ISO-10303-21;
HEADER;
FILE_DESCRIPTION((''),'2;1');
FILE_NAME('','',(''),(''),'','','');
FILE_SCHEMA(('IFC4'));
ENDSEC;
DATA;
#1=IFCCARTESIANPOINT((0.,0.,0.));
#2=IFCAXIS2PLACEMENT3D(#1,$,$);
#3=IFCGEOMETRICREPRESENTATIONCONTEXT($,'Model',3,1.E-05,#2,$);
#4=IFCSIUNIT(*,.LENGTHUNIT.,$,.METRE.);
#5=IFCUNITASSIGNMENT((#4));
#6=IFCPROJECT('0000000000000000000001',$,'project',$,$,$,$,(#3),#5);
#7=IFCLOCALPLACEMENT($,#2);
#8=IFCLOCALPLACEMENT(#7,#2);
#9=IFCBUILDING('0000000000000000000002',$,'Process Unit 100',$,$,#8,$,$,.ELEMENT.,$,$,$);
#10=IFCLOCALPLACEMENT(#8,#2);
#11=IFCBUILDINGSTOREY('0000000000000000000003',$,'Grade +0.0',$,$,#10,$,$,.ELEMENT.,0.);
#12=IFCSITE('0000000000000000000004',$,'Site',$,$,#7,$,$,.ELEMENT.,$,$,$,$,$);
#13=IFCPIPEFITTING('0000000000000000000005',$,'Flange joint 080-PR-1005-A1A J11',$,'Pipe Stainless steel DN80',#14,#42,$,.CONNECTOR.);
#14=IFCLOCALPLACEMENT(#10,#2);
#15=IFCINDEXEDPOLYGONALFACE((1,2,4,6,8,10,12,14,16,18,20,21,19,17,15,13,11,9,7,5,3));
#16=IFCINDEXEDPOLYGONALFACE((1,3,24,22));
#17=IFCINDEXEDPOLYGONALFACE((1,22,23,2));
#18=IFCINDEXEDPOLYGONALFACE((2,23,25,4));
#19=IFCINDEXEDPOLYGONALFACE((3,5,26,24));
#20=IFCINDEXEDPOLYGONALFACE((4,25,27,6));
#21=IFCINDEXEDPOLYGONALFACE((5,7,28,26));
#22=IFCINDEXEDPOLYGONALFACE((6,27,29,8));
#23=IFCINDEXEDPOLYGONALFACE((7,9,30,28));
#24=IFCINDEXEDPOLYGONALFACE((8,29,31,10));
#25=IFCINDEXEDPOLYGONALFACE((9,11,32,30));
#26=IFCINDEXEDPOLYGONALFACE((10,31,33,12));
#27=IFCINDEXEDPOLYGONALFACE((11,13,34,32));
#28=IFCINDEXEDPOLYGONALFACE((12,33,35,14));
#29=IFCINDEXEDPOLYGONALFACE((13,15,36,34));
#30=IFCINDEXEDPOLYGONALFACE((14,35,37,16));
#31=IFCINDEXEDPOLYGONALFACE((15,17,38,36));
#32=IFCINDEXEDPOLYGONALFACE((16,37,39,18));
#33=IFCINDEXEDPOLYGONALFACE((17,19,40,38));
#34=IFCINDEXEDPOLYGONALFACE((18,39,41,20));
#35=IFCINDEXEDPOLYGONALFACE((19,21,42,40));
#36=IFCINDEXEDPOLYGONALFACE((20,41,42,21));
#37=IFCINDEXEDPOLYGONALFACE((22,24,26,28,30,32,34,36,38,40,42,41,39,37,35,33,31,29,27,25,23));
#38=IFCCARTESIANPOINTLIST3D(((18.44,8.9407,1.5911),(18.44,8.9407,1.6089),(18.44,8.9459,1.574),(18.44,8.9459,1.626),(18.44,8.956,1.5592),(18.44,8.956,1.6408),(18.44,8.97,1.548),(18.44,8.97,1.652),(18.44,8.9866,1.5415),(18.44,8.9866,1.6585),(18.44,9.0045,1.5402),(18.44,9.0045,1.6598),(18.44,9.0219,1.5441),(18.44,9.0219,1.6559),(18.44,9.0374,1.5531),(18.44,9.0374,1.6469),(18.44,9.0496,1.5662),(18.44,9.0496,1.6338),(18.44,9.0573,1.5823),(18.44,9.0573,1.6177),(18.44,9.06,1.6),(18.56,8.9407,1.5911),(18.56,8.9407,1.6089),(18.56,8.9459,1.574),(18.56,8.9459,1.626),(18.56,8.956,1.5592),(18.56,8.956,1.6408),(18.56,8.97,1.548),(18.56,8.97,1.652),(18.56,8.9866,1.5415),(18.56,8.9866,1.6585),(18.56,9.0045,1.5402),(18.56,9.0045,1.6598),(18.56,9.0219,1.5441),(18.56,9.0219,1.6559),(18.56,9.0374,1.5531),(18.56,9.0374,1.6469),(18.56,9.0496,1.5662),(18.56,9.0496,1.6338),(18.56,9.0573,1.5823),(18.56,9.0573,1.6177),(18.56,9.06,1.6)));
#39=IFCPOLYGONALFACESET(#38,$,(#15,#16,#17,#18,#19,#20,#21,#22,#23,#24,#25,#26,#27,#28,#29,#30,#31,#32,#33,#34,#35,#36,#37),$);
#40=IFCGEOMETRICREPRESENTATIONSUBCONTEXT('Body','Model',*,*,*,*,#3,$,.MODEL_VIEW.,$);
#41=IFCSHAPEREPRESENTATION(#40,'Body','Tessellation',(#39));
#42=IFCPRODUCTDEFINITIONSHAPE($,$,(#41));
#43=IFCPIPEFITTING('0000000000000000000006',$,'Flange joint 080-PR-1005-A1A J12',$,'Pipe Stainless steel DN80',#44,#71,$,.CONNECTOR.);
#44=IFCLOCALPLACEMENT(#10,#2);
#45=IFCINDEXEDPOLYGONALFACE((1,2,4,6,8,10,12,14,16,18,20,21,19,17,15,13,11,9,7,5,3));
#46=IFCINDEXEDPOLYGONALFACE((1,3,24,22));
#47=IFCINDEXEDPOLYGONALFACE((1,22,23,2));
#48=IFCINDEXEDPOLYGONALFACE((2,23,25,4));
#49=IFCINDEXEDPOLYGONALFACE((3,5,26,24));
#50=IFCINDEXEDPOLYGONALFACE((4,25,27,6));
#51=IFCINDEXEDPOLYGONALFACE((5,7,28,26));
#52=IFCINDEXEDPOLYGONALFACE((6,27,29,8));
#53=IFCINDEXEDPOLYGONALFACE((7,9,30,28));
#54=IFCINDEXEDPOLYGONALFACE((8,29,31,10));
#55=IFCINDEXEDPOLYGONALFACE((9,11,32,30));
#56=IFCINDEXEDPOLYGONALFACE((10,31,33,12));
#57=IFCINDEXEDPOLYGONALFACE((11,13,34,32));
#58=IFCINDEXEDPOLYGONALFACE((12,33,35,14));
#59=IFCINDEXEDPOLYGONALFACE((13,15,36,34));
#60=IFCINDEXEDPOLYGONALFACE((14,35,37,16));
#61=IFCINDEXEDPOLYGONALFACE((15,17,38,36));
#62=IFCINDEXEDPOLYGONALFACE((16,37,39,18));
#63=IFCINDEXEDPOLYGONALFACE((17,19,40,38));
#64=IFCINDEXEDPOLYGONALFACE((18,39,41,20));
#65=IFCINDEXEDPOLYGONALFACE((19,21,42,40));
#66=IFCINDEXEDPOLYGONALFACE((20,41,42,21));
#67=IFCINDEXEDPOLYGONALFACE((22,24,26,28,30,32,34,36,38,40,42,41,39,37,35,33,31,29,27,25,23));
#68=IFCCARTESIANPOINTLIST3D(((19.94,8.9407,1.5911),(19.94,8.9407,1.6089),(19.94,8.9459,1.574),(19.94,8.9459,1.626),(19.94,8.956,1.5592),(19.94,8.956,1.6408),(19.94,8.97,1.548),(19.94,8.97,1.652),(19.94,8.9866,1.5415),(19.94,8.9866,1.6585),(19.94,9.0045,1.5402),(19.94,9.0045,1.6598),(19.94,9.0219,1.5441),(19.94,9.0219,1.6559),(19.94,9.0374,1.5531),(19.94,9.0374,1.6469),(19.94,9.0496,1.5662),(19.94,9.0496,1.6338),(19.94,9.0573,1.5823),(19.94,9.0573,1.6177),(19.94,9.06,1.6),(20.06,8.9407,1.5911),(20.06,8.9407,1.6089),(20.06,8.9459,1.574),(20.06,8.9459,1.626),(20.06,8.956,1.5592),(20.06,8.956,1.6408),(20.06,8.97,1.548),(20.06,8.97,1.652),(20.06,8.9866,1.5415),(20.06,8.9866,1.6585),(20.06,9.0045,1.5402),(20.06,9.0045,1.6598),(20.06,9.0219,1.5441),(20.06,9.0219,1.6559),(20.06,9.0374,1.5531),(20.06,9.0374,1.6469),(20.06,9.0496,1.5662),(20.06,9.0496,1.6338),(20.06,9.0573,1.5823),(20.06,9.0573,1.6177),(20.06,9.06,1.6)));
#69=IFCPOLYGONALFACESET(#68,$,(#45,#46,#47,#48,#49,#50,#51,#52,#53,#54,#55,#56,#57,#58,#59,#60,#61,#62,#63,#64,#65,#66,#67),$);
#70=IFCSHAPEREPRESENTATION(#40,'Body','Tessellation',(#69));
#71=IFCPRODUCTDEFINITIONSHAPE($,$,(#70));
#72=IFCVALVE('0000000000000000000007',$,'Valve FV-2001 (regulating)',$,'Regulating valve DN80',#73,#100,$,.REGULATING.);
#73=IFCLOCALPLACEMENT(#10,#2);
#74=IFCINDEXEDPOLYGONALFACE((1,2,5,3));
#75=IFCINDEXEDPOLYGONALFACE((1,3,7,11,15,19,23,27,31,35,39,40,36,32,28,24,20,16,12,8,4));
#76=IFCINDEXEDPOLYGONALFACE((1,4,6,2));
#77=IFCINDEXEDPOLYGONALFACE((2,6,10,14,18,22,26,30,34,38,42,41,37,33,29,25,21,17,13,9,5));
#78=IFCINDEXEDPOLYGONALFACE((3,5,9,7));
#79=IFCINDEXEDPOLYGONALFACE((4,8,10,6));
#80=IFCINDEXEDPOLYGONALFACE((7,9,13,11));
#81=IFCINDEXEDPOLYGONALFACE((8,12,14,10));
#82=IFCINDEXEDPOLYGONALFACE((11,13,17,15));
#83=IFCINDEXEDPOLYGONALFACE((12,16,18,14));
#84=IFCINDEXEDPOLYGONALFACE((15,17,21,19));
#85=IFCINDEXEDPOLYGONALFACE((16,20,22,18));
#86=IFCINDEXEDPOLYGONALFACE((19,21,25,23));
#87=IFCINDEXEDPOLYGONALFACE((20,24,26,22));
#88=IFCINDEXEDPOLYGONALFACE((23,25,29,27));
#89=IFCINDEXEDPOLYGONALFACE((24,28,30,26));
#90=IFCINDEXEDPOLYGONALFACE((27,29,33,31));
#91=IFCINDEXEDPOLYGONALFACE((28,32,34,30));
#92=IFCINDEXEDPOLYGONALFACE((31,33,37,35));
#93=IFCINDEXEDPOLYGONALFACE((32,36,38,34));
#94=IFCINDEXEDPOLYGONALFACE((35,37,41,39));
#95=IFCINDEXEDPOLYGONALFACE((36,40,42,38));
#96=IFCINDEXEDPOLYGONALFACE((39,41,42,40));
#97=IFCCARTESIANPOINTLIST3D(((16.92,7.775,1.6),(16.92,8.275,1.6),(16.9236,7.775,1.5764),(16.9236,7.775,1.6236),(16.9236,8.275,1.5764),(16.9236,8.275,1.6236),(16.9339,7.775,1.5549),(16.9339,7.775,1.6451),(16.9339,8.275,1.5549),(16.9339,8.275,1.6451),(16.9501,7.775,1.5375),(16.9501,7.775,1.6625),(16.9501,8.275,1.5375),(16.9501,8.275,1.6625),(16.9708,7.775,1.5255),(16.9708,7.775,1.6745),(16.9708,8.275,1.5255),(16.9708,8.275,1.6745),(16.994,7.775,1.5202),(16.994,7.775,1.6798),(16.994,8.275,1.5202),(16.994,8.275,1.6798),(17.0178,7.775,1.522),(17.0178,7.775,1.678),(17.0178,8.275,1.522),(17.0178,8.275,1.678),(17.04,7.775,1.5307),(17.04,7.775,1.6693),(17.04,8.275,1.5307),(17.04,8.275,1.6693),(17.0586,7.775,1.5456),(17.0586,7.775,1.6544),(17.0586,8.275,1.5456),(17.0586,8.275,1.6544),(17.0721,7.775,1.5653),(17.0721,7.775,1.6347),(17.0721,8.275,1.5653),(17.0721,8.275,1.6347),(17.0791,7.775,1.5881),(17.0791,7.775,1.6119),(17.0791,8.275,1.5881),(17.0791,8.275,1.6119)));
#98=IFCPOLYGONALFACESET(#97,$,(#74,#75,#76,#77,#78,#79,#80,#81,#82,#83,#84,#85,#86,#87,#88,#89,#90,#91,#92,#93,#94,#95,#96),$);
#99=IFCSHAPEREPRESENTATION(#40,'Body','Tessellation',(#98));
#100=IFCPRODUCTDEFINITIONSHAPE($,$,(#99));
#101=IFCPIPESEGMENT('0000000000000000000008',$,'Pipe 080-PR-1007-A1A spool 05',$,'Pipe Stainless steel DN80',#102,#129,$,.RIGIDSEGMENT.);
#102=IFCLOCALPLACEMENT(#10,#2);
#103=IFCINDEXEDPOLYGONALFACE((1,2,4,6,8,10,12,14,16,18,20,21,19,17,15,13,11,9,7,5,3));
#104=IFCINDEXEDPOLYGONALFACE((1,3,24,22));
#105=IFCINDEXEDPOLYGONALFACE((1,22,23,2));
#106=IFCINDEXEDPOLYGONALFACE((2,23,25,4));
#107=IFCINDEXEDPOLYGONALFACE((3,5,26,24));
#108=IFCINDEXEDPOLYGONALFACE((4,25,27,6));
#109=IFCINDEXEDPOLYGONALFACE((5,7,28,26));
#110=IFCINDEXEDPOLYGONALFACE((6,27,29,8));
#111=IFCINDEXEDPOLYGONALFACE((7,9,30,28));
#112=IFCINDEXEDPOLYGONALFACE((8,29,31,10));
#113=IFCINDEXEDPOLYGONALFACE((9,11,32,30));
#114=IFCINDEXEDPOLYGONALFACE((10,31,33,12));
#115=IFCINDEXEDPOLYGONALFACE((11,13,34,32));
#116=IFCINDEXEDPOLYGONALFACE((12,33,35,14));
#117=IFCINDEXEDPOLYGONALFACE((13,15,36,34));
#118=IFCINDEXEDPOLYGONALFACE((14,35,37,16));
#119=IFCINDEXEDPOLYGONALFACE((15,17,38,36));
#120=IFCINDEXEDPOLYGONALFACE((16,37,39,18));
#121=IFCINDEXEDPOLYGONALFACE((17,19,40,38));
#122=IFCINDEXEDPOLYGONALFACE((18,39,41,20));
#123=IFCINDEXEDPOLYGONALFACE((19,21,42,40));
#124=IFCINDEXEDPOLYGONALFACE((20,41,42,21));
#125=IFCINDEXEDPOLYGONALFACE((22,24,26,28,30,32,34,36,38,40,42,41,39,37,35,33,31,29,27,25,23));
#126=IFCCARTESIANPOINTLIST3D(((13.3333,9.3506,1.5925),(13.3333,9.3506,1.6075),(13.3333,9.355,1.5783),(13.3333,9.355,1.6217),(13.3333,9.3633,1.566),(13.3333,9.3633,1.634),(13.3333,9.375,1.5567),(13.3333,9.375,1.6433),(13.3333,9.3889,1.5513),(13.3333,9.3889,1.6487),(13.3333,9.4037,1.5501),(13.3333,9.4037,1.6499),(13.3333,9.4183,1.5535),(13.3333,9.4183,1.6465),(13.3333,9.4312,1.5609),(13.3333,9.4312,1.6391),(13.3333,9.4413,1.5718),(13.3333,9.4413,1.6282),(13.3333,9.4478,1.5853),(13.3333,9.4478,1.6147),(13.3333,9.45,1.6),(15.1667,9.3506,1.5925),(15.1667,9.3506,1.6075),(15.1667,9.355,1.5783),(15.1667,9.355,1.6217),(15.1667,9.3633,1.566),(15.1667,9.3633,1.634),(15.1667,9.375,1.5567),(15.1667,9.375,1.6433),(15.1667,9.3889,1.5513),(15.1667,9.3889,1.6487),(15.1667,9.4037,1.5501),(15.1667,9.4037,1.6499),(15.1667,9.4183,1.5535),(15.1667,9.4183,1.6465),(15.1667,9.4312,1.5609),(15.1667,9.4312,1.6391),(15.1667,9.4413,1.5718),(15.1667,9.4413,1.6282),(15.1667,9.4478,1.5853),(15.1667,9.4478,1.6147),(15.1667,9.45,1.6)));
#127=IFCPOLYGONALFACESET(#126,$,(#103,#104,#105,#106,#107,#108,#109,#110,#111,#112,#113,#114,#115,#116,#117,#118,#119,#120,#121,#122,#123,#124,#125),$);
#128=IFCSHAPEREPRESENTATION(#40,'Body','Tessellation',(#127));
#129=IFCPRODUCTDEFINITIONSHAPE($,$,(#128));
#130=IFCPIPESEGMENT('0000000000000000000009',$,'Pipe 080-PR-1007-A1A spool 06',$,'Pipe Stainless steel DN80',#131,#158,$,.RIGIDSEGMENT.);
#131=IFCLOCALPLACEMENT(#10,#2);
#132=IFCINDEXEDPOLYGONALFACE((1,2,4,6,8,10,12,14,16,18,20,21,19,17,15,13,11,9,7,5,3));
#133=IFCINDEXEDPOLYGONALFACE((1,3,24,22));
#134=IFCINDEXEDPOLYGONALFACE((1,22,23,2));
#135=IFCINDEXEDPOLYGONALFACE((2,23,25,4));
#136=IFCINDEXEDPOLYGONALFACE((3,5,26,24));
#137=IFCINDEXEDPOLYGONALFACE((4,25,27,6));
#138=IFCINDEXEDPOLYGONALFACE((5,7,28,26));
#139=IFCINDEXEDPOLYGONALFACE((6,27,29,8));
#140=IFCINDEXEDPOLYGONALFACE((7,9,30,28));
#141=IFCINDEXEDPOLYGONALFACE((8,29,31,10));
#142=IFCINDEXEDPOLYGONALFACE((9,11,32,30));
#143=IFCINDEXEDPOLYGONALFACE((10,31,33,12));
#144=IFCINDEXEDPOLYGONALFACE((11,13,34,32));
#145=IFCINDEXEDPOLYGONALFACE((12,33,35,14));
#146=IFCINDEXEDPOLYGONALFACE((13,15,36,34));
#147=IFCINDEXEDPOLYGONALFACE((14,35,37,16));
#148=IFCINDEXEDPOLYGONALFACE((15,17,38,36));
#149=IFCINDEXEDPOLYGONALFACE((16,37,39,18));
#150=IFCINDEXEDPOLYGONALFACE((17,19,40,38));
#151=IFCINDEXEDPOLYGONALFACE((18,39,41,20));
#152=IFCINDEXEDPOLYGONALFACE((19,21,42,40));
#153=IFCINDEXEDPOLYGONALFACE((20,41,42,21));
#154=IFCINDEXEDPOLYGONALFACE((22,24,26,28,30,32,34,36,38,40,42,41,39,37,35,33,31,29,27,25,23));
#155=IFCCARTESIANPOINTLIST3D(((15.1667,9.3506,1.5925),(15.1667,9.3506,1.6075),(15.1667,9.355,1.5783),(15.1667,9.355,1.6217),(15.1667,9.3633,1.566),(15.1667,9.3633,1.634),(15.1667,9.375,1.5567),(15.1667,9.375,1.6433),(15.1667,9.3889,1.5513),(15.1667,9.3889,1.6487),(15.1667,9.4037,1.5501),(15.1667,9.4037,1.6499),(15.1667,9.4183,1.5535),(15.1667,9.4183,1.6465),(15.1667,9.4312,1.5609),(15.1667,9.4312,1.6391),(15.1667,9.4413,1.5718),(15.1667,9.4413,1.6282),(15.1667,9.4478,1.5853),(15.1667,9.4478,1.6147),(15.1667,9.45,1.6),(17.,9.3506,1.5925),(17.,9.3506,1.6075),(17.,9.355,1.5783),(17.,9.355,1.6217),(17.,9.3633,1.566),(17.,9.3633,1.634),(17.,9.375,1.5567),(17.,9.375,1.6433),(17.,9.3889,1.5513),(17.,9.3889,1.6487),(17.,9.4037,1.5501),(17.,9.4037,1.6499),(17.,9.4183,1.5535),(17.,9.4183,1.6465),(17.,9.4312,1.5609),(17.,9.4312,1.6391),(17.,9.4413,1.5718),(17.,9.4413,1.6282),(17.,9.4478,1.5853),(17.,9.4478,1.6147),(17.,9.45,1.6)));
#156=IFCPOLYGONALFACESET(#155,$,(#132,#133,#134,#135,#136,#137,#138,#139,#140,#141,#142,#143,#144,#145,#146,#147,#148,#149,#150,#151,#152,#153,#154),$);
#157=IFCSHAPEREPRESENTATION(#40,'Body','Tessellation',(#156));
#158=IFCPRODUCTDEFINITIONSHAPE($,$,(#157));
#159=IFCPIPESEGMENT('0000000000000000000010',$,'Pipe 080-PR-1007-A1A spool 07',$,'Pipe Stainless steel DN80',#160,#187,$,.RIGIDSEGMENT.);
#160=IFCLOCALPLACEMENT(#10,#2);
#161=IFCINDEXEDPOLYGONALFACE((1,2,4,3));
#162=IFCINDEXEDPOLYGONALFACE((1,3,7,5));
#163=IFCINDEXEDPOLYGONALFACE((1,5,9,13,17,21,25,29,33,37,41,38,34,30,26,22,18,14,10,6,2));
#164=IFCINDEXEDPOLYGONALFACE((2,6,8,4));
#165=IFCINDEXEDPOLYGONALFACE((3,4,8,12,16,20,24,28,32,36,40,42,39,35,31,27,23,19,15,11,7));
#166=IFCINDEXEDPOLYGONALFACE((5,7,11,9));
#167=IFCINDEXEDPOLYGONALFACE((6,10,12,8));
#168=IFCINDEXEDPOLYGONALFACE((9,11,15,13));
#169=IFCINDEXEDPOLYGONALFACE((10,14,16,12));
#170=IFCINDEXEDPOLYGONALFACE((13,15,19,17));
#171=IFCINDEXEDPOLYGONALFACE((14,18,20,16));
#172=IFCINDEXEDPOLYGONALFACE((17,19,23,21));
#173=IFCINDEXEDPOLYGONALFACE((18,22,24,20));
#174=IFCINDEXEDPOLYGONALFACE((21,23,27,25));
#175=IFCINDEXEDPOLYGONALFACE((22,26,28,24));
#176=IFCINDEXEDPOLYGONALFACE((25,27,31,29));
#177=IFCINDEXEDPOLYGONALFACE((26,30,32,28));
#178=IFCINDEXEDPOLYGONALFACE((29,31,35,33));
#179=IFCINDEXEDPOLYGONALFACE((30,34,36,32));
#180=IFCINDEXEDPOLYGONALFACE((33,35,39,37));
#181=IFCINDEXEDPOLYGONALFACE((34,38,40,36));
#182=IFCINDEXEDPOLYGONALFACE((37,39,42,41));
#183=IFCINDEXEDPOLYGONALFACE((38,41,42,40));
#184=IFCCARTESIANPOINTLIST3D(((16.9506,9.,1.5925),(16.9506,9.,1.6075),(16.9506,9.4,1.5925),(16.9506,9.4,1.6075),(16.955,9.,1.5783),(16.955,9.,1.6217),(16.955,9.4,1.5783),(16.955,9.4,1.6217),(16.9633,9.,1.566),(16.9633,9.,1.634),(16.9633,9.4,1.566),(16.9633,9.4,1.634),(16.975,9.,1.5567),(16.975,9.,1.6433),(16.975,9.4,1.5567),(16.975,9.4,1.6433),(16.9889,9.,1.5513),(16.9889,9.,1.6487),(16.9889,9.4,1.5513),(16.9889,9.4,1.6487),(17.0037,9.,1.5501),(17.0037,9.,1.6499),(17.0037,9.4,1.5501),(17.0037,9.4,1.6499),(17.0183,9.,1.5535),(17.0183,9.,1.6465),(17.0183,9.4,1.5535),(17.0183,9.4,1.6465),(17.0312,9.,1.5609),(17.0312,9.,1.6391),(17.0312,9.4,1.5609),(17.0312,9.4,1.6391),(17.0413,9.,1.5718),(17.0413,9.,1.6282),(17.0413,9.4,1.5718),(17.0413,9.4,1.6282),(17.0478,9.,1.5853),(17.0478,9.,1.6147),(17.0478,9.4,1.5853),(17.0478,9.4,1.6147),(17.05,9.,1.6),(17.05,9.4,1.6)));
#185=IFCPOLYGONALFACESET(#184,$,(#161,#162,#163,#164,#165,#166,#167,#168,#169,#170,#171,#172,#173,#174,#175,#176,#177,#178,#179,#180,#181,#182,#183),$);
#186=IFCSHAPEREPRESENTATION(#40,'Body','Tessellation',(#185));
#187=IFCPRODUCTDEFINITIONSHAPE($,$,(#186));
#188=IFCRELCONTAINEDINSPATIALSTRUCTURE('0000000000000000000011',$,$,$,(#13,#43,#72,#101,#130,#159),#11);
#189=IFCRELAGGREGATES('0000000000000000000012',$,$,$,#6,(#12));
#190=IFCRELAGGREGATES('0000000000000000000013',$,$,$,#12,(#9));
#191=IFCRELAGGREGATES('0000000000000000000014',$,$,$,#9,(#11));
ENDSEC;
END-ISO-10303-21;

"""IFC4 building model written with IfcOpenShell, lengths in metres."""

from ifc_helpers import new_model, si_unit, frame, origin, place, context, subcontext, project, spatial, circle, extrude, element, save


model = new_model("IFC4")

# Units and contexts
model_context = context("Model", 3, precision=1e-05, world=origin())
body_context = subcontext(model_context, "Body", "Model", "MODEL_VIEW")
ifc_project = project(units=[si_unit("LENGTHUNIT", "METRE")], contexts=[model_context])

# Site, building, storey
site_placement = place(None, origin())
site = spatial("IfcSite", under=ifc_project, at=site_placement, Name="Site", CompositionType="ELEMENT")
building_placement = place(site_placement, origin())
building = spatial("IfcBuilding", under=site, at=building_placement, Name="Process Unit 100", CompositionType="ELEMENT")
storey_placement = place(building_placement, origin())
storey = spatial("IfcBuildingStorey", under=building, at=storey_placement, Name="Grade +0.0", CompositionType="ELEMENT", Elevation=0.0)

# Pipe fittings
for number, where, z_axis, x_axis, name in (
    (1, (18.44, 9.0, 1.6), (1.0, 0.0, 0.0), (0.0, 1.0, 0.0), "Flange joint 080-PR-1005-A1A J11"),
    (2, (19.94, 9.0, 1.6), (1.0, 0.0, 0.0), (0.0, 1.0, 0.0), "Flange joint 080-PR-1005-A1A J12"),
):
    element("IfcPipeFitting", number, at=place(storey_placement, frame(where, z_axis=z_axis, x_axis=x_axis)), inside=storey, Name=name, ObjectType="Pipe Stainless steel DN80", PredefinedType="CONNECTOR", context=body_context, shape_type="SweptSolid", body=[
        extrude(circle(Radius=0.06), origin(), (0.0, 0.0, 1.0), 0.12),
    ])

# Valve
valve_placement = place(storey_placement, frame((17.0, 7.775, 1.6), z_axis=(0.0, 1.0, 0.0), x_axis=(-1.0, 0.0, 0.0)))
element("IfcValve", 3, at=valve_placement, inside=storey, Name="Valve FV-2001 (regulating)", ObjectType="Regulating valve DN80", PredefinedType="REGULATING", context=body_context, shape_type="SweptSolid", body=[
    extrude(circle(Radius=0.08), origin(), (0.0, 0.0, 1.0), 0.5),
])

# Pipe segments
for number, where, z_axis, x_axis, name in (
    (4, (13.3333, 9.4, 1.6), (1.0, 0.0, 0.0), (0.0, 1.0, 0.0), "Pipe 080-PR-1007-A1A spool 05"),
    (5, (15.1667, 9.4, 1.6), (1.0, 0.0, 0.0), (0.0, 1.0, 0.0), "Pipe 080-PR-1007-A1A spool 06"),
):
    element("IfcPipeSegment", number, at=place(storey_placement, frame(where, z_axis=z_axis, x_axis=x_axis)), inside=storey, Name=name, ObjectType="Pipe Stainless steel DN80", PredefinedType="RIGIDSEGMENT", context=body_context, shape_type="SweptSolid", body=[
        extrude(circle(Radius=0.05), origin(), (0.0, 0.0, 1.0), 1.8333),
    ])
pipe_segment_1_placement = place(storey_placement, frame((17.0, 9.4, 1.6), z_axis=(0.0, -1.0, 0.0), x_axis=(1.0, 0.0, 0.0)))
element("IfcPipeSegment", 6, at=pipe_segment_1_placement, inside=storey, Name="Pipe 080-PR-1007-A1A spool 07", ObjectType="Pipe Stainless steel DN80", PredefinedType="RIGIDSEGMENT", context=body_context, shape_type="SweptSolid", body=[
    extrude(circle(Radius=0.05), origin(), (0.0, 0.0, 1.0), 0.4),
])

save(model, "model.ifc")
